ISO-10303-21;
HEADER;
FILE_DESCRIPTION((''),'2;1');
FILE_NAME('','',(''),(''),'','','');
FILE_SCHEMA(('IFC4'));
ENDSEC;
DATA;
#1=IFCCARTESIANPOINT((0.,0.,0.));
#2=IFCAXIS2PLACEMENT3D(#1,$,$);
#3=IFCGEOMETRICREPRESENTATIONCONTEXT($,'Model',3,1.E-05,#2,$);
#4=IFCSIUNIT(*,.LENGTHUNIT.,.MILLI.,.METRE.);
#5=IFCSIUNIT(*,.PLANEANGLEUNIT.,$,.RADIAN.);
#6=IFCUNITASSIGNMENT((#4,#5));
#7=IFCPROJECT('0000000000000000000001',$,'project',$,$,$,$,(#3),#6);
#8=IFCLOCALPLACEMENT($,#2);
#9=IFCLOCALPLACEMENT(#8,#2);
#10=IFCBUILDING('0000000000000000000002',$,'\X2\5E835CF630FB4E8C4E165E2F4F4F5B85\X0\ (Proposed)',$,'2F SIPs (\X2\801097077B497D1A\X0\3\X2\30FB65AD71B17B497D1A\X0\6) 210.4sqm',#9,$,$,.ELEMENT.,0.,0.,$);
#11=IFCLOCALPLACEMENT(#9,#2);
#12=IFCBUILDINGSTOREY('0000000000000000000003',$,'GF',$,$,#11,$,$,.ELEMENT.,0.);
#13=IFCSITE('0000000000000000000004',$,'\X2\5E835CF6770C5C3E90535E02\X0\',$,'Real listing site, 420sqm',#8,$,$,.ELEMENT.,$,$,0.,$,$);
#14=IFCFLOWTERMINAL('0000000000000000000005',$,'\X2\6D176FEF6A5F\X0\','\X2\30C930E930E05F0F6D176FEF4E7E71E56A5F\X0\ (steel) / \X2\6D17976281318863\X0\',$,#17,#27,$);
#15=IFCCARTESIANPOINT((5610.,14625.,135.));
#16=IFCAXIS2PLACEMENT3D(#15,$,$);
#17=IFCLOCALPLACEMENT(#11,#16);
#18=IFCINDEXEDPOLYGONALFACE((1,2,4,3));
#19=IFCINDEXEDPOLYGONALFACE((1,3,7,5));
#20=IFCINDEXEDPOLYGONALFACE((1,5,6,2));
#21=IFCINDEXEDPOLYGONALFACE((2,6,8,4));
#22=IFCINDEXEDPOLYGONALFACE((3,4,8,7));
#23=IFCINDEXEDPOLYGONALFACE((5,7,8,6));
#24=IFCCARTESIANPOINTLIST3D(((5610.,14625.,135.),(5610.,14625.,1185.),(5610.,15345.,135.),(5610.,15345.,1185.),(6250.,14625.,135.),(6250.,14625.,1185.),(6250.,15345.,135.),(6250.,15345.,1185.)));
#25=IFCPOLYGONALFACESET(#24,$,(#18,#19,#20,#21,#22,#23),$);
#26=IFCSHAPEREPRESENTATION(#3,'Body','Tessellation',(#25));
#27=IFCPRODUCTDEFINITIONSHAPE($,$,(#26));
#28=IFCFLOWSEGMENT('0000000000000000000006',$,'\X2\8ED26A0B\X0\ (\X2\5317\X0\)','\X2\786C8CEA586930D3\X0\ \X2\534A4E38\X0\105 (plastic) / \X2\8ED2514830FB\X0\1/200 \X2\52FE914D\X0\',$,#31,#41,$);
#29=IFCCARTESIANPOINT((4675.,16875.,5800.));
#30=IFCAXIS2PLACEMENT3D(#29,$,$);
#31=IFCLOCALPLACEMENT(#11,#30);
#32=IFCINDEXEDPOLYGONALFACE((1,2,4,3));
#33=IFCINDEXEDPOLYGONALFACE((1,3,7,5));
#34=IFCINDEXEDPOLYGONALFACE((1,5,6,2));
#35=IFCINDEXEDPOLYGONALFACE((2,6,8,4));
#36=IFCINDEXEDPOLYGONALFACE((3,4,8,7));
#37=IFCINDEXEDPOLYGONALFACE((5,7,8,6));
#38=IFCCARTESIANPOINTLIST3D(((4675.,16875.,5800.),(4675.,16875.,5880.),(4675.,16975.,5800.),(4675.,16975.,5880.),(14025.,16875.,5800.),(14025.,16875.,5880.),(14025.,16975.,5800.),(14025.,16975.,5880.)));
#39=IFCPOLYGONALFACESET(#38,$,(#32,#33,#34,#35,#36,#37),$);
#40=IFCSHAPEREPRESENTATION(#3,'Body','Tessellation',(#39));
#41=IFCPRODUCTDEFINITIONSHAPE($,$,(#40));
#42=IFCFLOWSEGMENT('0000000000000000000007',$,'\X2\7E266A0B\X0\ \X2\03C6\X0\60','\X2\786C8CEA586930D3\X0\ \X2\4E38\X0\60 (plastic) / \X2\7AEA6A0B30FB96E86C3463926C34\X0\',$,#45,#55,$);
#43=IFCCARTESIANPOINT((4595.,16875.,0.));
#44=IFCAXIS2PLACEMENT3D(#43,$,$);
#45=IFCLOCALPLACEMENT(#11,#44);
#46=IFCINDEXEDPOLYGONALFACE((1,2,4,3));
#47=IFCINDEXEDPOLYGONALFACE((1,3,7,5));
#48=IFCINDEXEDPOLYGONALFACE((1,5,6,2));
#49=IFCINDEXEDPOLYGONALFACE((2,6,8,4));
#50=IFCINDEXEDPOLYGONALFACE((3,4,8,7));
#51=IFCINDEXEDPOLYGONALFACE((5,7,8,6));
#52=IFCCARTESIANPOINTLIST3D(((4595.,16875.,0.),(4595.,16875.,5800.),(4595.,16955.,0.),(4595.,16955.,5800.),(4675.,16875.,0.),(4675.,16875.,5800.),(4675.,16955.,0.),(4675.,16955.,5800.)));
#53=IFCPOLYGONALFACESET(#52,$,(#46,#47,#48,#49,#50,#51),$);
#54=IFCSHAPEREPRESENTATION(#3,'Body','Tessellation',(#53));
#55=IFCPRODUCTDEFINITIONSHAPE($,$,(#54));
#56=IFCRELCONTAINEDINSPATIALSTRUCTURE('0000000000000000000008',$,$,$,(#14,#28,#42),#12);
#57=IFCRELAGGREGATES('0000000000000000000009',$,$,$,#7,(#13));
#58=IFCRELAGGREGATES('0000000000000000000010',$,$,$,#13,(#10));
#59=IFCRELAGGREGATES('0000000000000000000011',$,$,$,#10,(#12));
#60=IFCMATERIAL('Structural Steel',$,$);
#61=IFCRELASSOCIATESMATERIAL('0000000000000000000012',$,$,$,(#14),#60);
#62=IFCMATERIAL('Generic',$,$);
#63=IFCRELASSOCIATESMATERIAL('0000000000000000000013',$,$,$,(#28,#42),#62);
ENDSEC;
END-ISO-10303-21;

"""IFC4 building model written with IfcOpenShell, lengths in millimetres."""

from ifc_helpers import new_model, si_unit, frame, frame_2d, origin, place, context, project, spatial, rectangle, extrude, material, element, save


model = new_model("IFC4")

# Units and contexts
model_context = context("Model", 3, precision=1e-05, world=origin())
ifc_project = project(units=[si_unit("LENGTHUNIT", "METRE", prefix="MILLI"), si_unit("PLANEANGLEUNIT", "RADIAN")], contexts=[model_context])

# Site, building, storey
site_placement = place(None, origin())
site = spatial("IfcSite", under=ifc_project, at=site_placement, Name="広島県尾道市", ObjectType="Real listing site, 420sqm", CompositionType="ELEMENT", RefElevation=0.0)
building_placement = place(site_placement, origin())
building = spatial("IfcBuilding", under=site, at=building_placement, Name="広島・二世帯住宅 (Proposed)", ObjectType="2F SIPs (耐震等級3・断熱等級6) 210.4sqm", CompositionType="ELEMENT", ElevationOfRefHeight=0.0, ElevationOfTerrain=0.0)
storey_placement = place(building_placement, origin())
storey = spatial("IfcBuildingStorey", under=building, at=storey_placement, Name="GF", CompositionType="ELEMENT", Elevation=0.0)

# Flow terminal
ifc_material_1 = material(Name="Structural Steel")
flow_terminal_placement = place(storey_placement, frame((5610.0, 14625.0, 135.0)))
element("IfcFlowTerminal", 1, at=flow_terminal_placement, inside=storey, material=ifc_material_1, Name="洗濯機", Description="ドラム式洗濯乾燥機 (steel) / 洗面脱衣", context=model_context, shape_type="SweptSolid", body=[
    extrude(rectangle(XDim=640.0, YDim=720.0, at=frame_2d((320.0, 360.0))), frame((5610.0, 14625.0, 135.0)), (0.0, 0.0, 1.0), 1050.0),
])

# Flow segments
ifc_material_2 = material(Name="Generic")
flow_segment_1_placement = place(storey_placement, frame((4675.0, 16875.0, 5800.0)))
element("IfcFlowSegment", 2, at=flow_segment_1_placement, inside=storey, material=ifc_material_2, Name="軒樋 (北)", Description="硬質塩ビ 半丸105 (plastic) / 軒先・1/200 勾配", context=model_context, shape_type="SweptSolid", body=[
    extrude(rectangle(XDim=9350.0, YDim=100.0, at=frame_2d((4675.0, 50.0))), frame((4675.0, 16875.0, 5800.0)), (0.0, 0.0, 1.0), 80.0),
])
flow_segment_2_placement = place(storey_placement, frame((4595.0, 16875.0, 0.0)))
element("IfcFlowSegment", 3, at=flow_segment_2_placement, inside=storey, material=ifc_material_2, Name="縦樋 φ60", Description="硬質塩ビ 丸60 (plastic) / 竪樋・雨水排水", context=model_context, shape_type="SweptSolid", body=[
    extrude(rectangle(XDim=80.0, YDim=80.0, at=frame_2d((40.0, 40.0))), frame((4595.0, 16875.0, 0.0)), (0.0, 0.0, 1.0), 5800.0),
])

save(model, "model.ifc")
